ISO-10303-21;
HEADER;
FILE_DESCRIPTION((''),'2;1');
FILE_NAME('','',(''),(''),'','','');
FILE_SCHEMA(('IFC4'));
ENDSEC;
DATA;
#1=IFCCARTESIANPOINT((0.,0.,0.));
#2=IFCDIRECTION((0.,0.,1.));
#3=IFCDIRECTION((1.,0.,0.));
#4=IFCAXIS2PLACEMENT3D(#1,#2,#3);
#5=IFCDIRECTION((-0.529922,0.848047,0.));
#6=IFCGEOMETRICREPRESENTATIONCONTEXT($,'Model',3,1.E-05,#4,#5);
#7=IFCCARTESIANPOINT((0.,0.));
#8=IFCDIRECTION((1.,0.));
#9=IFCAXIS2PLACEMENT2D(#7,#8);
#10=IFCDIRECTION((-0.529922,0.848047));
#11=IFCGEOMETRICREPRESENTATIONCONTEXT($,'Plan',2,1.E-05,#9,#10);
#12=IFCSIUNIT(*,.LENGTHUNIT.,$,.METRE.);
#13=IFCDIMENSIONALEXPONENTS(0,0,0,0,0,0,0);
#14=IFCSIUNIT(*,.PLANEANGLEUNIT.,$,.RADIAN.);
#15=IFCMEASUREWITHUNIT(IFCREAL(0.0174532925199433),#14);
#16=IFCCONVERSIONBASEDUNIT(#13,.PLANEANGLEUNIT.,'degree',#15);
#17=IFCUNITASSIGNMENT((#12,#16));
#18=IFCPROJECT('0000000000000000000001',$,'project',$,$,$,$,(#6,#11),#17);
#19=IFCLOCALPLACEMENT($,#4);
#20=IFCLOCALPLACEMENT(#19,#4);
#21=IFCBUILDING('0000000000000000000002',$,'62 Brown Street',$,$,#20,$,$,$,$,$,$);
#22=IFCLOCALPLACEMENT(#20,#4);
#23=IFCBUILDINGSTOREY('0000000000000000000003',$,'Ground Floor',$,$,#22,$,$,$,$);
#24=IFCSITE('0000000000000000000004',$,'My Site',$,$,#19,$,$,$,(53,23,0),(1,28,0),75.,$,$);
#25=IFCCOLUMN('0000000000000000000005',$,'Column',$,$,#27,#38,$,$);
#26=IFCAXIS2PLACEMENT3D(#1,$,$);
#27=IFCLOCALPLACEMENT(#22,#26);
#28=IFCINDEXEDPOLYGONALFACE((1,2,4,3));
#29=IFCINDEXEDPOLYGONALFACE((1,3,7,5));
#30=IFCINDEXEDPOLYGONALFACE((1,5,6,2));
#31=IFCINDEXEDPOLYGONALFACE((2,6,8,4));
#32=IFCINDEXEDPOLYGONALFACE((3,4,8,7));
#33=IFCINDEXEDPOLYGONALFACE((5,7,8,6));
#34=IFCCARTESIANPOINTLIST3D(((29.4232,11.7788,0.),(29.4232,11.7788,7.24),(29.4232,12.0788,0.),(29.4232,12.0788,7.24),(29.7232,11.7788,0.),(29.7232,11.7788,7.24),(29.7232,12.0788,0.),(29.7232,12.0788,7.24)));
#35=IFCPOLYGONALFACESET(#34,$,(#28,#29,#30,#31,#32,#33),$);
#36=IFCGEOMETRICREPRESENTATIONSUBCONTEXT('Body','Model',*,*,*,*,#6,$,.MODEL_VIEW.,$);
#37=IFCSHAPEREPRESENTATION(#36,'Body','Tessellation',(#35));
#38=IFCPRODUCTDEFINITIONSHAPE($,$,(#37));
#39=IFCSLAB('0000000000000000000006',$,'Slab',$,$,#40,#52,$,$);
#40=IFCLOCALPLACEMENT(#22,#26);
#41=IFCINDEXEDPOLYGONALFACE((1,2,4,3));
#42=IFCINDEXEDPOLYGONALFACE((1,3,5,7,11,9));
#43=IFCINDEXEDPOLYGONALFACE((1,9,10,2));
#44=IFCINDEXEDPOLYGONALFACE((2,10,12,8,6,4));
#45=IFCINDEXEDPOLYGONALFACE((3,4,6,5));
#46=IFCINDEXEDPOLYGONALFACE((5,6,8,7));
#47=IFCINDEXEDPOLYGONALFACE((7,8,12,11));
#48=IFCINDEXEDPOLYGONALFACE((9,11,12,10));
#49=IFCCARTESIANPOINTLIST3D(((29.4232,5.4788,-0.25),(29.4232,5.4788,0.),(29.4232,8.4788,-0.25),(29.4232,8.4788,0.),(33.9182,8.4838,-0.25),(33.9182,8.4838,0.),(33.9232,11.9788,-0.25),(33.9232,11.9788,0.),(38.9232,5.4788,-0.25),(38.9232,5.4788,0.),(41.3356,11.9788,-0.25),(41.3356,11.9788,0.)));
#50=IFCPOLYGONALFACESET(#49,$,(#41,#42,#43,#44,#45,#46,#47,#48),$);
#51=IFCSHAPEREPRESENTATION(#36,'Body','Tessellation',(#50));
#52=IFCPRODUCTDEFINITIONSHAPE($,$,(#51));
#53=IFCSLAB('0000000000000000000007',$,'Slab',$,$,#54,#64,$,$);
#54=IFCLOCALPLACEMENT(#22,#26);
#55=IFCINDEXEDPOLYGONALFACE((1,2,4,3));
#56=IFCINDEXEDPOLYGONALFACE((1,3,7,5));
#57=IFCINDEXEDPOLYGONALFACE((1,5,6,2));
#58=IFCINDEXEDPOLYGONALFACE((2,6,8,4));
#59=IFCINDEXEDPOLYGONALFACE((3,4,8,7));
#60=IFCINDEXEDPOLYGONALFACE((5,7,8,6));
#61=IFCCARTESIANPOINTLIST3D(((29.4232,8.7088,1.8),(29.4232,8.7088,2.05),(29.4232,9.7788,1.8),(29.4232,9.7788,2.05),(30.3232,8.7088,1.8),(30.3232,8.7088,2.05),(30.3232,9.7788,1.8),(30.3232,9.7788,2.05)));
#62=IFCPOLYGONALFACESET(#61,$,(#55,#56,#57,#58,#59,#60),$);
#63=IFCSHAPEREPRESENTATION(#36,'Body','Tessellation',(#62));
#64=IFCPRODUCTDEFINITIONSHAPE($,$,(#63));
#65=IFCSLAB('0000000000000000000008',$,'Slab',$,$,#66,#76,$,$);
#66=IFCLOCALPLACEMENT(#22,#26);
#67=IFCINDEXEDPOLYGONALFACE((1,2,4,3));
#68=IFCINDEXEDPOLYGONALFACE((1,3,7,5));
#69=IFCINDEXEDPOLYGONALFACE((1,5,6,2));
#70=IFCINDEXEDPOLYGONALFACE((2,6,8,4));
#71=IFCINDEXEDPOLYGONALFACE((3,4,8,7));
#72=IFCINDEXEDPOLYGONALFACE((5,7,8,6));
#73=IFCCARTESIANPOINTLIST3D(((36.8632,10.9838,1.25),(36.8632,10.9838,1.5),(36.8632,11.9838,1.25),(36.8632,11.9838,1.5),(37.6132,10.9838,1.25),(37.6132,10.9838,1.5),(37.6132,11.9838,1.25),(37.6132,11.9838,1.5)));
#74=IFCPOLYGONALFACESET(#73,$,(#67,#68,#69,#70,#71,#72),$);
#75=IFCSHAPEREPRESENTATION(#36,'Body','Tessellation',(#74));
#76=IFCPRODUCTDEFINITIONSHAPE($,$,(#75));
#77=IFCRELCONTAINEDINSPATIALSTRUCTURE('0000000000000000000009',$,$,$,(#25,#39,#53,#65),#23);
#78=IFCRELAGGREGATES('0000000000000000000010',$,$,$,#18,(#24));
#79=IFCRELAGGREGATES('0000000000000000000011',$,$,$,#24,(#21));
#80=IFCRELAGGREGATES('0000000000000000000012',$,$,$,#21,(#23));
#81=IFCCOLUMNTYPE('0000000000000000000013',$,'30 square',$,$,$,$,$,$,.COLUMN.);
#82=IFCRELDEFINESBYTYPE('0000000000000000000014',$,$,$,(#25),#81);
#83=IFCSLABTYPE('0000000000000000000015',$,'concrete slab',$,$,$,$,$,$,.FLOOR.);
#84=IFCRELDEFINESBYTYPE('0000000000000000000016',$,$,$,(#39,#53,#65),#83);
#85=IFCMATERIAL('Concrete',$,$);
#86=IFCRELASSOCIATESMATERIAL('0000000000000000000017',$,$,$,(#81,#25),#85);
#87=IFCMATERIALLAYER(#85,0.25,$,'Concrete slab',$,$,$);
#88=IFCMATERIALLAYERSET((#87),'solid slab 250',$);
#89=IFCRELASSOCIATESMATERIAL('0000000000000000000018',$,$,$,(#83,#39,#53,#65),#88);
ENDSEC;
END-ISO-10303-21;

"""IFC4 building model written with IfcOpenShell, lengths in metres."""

from ifc_helpers import new_model, entity, si_unit, converted_unit, direction, frame, origin_with_axes, origin_2d_with_axis, place, context, subcontext, project, spatial, line, indexed_curve, rectangle, outline, extrude, material, layer, layer_set, layer_usage, material_profile, profile_set, profile_usage, type_object, element, save


model = new_model("IFC4")

# Units and contexts
model_context = context("Model", 3, precision=1e-05, world=origin_with_axes(), true_north=direction((-0.529922, 0.848047, 0.0)))
plan_context = context("Plan", 2, precision=1e-05, world=origin_2d_with_axis(), true_north=direction((-0.529922, 0.848047)))
body_context_1 = subcontext(model_context, "Body", "Model", "MODEL_VIEW")
ifc_project = project(units=[si_unit("LENGTHUNIT", "METRE"), converted_unit("PLANEANGLEUNIT", "degree", entity("IfcReal", 0.0174532925199433), si_unit("PLANEANGLEUNIT", "RADIAN"), dimensions=[0, 0, 0, 0, 0, 0, 0])], contexts=[model_context, plan_context])

# Site, building, storey
site_placement = place(None, origin_with_axes())
site = spatial("IfcSite", under=ifc_project, at=site_placement, Name="My Site", RefLatitude=(53, 23, 0), RefLongitude=(1, 28, 0), RefElevation=75.0)
building_placement = place(site_placement, origin_with_axes())
building = spatial("IfcBuilding", under=site, at=building_placement, Name="62 Brown Street")
storey_placement = place(building_placement, origin_with_axes())
storey = spatial("IfcBuildingStorey", under=building, at=storey_placement, Name="Ground Floor")

# Column
ifc_material_1 = material(Name="Concrete")
ifc_material_profile_1 = material_profile(ifc_material_1, rectangle(XDim=0.3, YDim=0.3))
ifc_profile_set_1 = profile_set([ifc_material_profile_1])
ifc_profile_usage_1 = profile_usage(ifc_profile_set_1, cardinal=5)
column_type = type_object("IfcColumnType", Name="30 square", PredefinedType="COLUMN", material=ifc_profile_set_1)
column_1_placement = place(storey_placement, frame((29.5732, 11.9288, 0.0), z_axis=(0.0, 0.0, 1.0), x_axis=(1.0, 0.0, 0.0)))
element("IfcColumn", 1, at=column_1_placement, inside=storey, type_object=column_type, material=ifc_profile_usage_1, Name="Column", context=body_context_1, shape_type="SweptSolid", body=[
    extrude(rectangle(XDim=0.3, YDim=0.3), origin_with_axes(), (0.0, 0.0, 1.0), 7.24),
])

# Slabs
ifc_layer_1 = layer(ifc_material_1, 0.25, Name="Concrete slab")
ifc_layer_set_1 = layer_set([ifc_layer_1], Name="solid slab 250")
ifc_layer_usage_1 = layer_usage(ifc_layer_set_1, "AXIS3", "POSITIVE", 0.0)
slab_type = type_object("IfcSlabType", Name="concrete slab", PredefinedType="FLOOR", material=ifc_layer_set_1)
slab_1_placement = place(storey_placement, frame((29.4232, 5.4788, -0.25), z_axis=(0.0, 0.0, 1.0), x_axis=(1.0, 0.0, 0.0)))
element("IfcSlab", 2, at=slab_1_placement, inside=storey, type_object=slab_type, material=ifc_layer_usage_1, Name="Slab", context=body_context_1, shape_type="SweptSolid", body=[
    extrude(outline(indexed_curve([(0.0, 0.0), (9.5, 0.0), (11.9124, 6.5), (0.0, 3.0), (4.5, 6.5), (4.495, 3.005)], segments=[line(1, 2), line(2, 3), line(3, 5), line(5, 6), line(6, 4), line(4, 1)], self_intersect=False)), None, (0.0, 0.0, 1.0), 0.25),
])
ifc_layer_usage_2 = layer_usage(ifc_layer_set_1, "AXIS3", "POSITIVE", 0.0)
slab_2_placement = place(storey_placement, frame((29.4232, 8.7088, 1.8), z_axis=(0.0, 0.0, 1.0), x_axis=(1.0, 0.0, 0.0)))
element("IfcSlab", 3, at=slab_2_placement, inside=storey, type_object=slab_type, material=ifc_layer_usage_2, Name="Slab", context=body_context_1, shape_type="SweptSolid", body=[
    extrude(outline(indexed_curve([(0.9, 1.07), (0.9, 0.0), (0.0, 0.0), (0.0, 1.07)], segments=[line(3, 2), line(2, 1), line(1, 4), line(4, 3)], self_intersect=False)), None, (0.0, 0.0, 1.0), 0.25),
])
ifc_layer_usage_3 = layer_usage(ifc_layer_set_1, "AXIS3", "POSITIVE", 0.0)
slab_3_placement = place(storey_placement, frame((36.8632, 10.9838, 1.25), z_axis=(0.0, 0.0, 1.0), x_axis=(1.0, 0.0, 0.0)))
element("IfcSlab", 4, at=slab_3_placement, inside=storey, type_object=slab_type, material=ifc_layer_usage_3, Name="Slab", context=body_context_1, shape_type="SweptSolid", body=[
    extrude(outline(indexed_curve([(0.0, 0.0), (0.75, 0.0), (0.75, 1.0), (0.0, 1.0)], segments=[line(4, 1), line(1, 2), line(2, 3), line(3, 4)], self_intersect=False)), None, (0.0, 0.0, 1.0), 0.25),
])

save(model, "model.ifc")
